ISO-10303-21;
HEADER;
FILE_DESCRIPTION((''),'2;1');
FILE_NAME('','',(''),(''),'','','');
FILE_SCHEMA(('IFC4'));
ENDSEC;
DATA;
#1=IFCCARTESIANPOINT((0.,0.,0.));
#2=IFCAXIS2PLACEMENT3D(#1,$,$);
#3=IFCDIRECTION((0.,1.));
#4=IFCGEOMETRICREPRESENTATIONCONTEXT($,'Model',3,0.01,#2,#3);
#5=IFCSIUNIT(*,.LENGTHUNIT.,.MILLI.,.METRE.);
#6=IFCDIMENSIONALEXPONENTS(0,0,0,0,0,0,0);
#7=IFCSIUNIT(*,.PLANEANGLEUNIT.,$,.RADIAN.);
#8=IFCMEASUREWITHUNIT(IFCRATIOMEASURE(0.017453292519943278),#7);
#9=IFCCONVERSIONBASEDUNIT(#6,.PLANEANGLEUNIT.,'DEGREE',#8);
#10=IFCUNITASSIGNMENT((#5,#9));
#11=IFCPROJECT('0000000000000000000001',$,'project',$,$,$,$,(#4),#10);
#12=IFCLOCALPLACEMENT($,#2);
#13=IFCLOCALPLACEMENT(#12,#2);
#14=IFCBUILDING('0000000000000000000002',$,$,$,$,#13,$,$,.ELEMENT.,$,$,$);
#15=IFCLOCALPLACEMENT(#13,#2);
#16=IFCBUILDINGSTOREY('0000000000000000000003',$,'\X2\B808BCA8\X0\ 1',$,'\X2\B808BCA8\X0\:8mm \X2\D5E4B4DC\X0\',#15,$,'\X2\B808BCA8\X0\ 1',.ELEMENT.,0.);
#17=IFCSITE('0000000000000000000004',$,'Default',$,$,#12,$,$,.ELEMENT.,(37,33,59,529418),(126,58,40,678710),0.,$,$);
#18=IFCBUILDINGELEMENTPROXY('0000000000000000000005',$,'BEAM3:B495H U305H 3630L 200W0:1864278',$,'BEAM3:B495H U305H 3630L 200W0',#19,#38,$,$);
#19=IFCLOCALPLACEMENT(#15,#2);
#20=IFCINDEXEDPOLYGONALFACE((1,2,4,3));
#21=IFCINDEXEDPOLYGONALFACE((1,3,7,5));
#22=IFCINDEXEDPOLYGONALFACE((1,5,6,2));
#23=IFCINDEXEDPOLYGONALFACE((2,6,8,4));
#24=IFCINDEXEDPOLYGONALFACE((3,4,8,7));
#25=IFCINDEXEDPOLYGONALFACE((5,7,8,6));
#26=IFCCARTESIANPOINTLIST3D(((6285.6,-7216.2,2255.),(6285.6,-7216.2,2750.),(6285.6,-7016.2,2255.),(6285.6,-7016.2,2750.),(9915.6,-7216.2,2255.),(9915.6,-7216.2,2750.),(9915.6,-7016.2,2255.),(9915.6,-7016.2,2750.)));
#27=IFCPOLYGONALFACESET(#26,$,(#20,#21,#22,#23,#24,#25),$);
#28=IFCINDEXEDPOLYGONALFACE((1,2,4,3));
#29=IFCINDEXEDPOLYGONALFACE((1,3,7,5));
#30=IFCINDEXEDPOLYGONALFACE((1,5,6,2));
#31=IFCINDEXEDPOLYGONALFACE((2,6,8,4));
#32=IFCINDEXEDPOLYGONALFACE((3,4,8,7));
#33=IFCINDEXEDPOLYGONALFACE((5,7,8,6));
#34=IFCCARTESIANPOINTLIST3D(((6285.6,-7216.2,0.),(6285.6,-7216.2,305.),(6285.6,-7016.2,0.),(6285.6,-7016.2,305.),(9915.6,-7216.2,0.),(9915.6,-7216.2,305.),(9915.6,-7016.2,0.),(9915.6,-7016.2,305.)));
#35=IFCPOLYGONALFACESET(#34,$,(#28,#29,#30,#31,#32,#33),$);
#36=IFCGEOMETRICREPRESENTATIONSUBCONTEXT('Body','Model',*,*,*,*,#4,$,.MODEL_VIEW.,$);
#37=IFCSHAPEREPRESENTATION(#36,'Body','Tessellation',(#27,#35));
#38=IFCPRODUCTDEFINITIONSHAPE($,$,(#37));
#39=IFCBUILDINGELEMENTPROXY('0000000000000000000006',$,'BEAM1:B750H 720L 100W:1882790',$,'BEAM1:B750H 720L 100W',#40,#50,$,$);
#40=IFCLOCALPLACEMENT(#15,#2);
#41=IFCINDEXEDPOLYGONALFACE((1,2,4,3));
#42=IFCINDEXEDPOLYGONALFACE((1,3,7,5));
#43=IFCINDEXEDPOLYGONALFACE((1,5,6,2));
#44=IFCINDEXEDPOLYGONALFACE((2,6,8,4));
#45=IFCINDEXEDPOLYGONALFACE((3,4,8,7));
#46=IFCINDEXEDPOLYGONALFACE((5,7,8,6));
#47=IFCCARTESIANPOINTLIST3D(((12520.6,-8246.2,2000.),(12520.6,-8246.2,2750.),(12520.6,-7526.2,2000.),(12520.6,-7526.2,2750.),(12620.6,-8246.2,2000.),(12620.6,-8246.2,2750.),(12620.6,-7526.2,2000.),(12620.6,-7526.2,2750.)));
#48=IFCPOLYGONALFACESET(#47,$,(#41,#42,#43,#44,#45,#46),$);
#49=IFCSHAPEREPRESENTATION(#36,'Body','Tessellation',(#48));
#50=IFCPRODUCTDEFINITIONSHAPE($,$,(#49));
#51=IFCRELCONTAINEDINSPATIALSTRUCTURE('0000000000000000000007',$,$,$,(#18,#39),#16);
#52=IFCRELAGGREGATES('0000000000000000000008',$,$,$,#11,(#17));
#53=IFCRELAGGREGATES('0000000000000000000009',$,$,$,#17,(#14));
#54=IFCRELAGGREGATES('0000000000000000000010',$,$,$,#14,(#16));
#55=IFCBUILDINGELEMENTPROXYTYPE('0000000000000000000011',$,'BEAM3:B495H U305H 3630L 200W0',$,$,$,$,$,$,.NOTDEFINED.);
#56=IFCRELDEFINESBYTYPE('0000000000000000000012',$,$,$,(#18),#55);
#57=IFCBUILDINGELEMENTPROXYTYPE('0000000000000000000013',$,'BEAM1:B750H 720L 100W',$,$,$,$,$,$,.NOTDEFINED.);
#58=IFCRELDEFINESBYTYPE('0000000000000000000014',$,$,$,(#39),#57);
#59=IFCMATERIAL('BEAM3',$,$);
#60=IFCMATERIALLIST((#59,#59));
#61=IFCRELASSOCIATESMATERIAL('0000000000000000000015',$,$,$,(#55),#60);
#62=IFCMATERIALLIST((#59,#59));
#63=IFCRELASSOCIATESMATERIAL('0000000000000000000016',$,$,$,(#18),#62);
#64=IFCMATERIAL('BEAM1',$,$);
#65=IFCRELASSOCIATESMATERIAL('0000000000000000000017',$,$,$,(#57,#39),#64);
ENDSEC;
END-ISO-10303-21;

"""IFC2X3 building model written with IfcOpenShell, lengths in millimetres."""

from ifc_helpers import new_model, entity, si_unit, converted_unit, direction, frame, origin, origin_2d_with_axis, place, context, subcontext, project, spatial, rectangle, extrude, source, transform, mapped, material, material_list, type_object, type_shapes, element, save


model = new_model("IFC2X3")

# Units and contexts
model_context = context("Model", 3, precision=0.01, world=origin(), true_north=direction((0.0, 1.0)))
body_context = subcontext(model_context, "Body", "Model", "MODEL_VIEW")
ifc_project = project(units=[si_unit("LENGTHUNIT", "METRE", prefix="MILLI"), converted_unit("PLANEANGLEUNIT", "DEGREE", entity("IfcRatioMeasure", 0.017453292519943278), si_unit("PLANEANGLEUNIT", "RADIAN"), dimensions=[0, 0, 0, 0, 0, 0, 0])], contexts=[model_context])

# Site, building, storey
site_placement = place(None, origin())
site = spatial("IfcSite", under=ifc_project, at=site_placement, Name="Default", CompositionType="ELEMENT", RefLatitude=(37, 33, 59, 529418), RefLongitude=(126, 58, 40, 678710), RefElevation=0.0)
building_placement = place(site_placement, origin())
building = spatial("IfcBuilding", under=site, at=building_placement, CompositionType="ELEMENT")
storey_placement = place(building_placement, origin())
storey = spatial("IfcBuildingStorey", under=building, at=storey_placement, Name="레벨 1", ObjectType="레벨:8mm 헤드", LongName="레벨 1", CompositionType="ELEMENT", Elevation=0.0)

# Building element proxies
ifc_material_1 = material(Name="BEAM3")
ifc_material_list_1 = material_list([ifc_material_1, ifc_material_1])
ifc_material_list_2 = material_list([ifc_material_1, ifc_material_1])
building_element_proxy_type_1 = type_object("IfcBuildingElementProxyType", Name="BEAM3:B495H U305H 3630L 200W0", PredefinedType="NOTDEFINED", material=ifc_material_list_2)
shared_shape_1 = source(origin(), body_context, "Body", "SweptSolid", [
    extrude(rectangle(XDim=3630.0, YDim=200.0, at=origin_2d_with_axis()), frame((1815.0, -100.0, 2255.0)), (0.0, 0.0, 1.0), 495.0),
    extrude(rectangle(XDim=3630.0, YDim=200.0, at=origin_2d_with_axis()), frame((1815.0, -100.0, 0.0)), (0.0, 0.0, 1.0), 305.0),
])
type_shapes(building_element_proxy_type_1, [shared_shape_1])
proxy_1_placement = place(storey_placement, frame((6285.6, -7016.2, 0.0)))
element("IfcBuildingElementProxy", 1, at=proxy_1_placement, inside=storey, type_object=building_element_proxy_type_1, material=ifc_material_list_1, Name="BEAM3:B495H U305H 3630L 200W0:1864278", ObjectType="BEAM3:B495H U305H 3630L 200W0", context=body_context, shape_type="MappedRepresentation", body=[
    mapped(shared_shape_1, transform((0.0, 0.0, 0.0), scale=1.0)),
])
ifc_material_2 = material(Name="BEAM1")
building_element_proxy_type_2 = type_object("IfcBuildingElementProxyType", Name="BEAM1:B750H 720L 100W", PredefinedType="NOTDEFINED", material=ifc_material_2)
shared_shape_2 = source(origin(), body_context, "Body", "SweptSolid", [
    extrude(rectangle(XDim=720.0, YDim=100.0, at=origin_2d_with_axis()), frame((360.0, -50.0, -750.0)), (0.0, 0.0, 1.0), 750.0),
])
type_shapes(building_element_proxy_type_2, [shared_shape_2])
proxy_2_placement = place(storey_placement, frame((12620.6, -7526.2, 2750.0), z_axis=(0.0, 0.0, 1.0), x_axis=(0.0, -1.0, 0.0)))
element("IfcBuildingElementProxy", 2, at=proxy_2_placement, inside=storey, type_object=building_element_proxy_type_2, material=ifc_material_2, Name="BEAM1:B750H 720L 100W:1882790", ObjectType="BEAM1:B750H 720L 100W", context=body_context, shape_type="MappedRepresentation", body=[
    mapped(shared_shape_2, transform((0.0, 0.0, 0.0), scale=1.0)),
])

save(model, "model.ifc")
